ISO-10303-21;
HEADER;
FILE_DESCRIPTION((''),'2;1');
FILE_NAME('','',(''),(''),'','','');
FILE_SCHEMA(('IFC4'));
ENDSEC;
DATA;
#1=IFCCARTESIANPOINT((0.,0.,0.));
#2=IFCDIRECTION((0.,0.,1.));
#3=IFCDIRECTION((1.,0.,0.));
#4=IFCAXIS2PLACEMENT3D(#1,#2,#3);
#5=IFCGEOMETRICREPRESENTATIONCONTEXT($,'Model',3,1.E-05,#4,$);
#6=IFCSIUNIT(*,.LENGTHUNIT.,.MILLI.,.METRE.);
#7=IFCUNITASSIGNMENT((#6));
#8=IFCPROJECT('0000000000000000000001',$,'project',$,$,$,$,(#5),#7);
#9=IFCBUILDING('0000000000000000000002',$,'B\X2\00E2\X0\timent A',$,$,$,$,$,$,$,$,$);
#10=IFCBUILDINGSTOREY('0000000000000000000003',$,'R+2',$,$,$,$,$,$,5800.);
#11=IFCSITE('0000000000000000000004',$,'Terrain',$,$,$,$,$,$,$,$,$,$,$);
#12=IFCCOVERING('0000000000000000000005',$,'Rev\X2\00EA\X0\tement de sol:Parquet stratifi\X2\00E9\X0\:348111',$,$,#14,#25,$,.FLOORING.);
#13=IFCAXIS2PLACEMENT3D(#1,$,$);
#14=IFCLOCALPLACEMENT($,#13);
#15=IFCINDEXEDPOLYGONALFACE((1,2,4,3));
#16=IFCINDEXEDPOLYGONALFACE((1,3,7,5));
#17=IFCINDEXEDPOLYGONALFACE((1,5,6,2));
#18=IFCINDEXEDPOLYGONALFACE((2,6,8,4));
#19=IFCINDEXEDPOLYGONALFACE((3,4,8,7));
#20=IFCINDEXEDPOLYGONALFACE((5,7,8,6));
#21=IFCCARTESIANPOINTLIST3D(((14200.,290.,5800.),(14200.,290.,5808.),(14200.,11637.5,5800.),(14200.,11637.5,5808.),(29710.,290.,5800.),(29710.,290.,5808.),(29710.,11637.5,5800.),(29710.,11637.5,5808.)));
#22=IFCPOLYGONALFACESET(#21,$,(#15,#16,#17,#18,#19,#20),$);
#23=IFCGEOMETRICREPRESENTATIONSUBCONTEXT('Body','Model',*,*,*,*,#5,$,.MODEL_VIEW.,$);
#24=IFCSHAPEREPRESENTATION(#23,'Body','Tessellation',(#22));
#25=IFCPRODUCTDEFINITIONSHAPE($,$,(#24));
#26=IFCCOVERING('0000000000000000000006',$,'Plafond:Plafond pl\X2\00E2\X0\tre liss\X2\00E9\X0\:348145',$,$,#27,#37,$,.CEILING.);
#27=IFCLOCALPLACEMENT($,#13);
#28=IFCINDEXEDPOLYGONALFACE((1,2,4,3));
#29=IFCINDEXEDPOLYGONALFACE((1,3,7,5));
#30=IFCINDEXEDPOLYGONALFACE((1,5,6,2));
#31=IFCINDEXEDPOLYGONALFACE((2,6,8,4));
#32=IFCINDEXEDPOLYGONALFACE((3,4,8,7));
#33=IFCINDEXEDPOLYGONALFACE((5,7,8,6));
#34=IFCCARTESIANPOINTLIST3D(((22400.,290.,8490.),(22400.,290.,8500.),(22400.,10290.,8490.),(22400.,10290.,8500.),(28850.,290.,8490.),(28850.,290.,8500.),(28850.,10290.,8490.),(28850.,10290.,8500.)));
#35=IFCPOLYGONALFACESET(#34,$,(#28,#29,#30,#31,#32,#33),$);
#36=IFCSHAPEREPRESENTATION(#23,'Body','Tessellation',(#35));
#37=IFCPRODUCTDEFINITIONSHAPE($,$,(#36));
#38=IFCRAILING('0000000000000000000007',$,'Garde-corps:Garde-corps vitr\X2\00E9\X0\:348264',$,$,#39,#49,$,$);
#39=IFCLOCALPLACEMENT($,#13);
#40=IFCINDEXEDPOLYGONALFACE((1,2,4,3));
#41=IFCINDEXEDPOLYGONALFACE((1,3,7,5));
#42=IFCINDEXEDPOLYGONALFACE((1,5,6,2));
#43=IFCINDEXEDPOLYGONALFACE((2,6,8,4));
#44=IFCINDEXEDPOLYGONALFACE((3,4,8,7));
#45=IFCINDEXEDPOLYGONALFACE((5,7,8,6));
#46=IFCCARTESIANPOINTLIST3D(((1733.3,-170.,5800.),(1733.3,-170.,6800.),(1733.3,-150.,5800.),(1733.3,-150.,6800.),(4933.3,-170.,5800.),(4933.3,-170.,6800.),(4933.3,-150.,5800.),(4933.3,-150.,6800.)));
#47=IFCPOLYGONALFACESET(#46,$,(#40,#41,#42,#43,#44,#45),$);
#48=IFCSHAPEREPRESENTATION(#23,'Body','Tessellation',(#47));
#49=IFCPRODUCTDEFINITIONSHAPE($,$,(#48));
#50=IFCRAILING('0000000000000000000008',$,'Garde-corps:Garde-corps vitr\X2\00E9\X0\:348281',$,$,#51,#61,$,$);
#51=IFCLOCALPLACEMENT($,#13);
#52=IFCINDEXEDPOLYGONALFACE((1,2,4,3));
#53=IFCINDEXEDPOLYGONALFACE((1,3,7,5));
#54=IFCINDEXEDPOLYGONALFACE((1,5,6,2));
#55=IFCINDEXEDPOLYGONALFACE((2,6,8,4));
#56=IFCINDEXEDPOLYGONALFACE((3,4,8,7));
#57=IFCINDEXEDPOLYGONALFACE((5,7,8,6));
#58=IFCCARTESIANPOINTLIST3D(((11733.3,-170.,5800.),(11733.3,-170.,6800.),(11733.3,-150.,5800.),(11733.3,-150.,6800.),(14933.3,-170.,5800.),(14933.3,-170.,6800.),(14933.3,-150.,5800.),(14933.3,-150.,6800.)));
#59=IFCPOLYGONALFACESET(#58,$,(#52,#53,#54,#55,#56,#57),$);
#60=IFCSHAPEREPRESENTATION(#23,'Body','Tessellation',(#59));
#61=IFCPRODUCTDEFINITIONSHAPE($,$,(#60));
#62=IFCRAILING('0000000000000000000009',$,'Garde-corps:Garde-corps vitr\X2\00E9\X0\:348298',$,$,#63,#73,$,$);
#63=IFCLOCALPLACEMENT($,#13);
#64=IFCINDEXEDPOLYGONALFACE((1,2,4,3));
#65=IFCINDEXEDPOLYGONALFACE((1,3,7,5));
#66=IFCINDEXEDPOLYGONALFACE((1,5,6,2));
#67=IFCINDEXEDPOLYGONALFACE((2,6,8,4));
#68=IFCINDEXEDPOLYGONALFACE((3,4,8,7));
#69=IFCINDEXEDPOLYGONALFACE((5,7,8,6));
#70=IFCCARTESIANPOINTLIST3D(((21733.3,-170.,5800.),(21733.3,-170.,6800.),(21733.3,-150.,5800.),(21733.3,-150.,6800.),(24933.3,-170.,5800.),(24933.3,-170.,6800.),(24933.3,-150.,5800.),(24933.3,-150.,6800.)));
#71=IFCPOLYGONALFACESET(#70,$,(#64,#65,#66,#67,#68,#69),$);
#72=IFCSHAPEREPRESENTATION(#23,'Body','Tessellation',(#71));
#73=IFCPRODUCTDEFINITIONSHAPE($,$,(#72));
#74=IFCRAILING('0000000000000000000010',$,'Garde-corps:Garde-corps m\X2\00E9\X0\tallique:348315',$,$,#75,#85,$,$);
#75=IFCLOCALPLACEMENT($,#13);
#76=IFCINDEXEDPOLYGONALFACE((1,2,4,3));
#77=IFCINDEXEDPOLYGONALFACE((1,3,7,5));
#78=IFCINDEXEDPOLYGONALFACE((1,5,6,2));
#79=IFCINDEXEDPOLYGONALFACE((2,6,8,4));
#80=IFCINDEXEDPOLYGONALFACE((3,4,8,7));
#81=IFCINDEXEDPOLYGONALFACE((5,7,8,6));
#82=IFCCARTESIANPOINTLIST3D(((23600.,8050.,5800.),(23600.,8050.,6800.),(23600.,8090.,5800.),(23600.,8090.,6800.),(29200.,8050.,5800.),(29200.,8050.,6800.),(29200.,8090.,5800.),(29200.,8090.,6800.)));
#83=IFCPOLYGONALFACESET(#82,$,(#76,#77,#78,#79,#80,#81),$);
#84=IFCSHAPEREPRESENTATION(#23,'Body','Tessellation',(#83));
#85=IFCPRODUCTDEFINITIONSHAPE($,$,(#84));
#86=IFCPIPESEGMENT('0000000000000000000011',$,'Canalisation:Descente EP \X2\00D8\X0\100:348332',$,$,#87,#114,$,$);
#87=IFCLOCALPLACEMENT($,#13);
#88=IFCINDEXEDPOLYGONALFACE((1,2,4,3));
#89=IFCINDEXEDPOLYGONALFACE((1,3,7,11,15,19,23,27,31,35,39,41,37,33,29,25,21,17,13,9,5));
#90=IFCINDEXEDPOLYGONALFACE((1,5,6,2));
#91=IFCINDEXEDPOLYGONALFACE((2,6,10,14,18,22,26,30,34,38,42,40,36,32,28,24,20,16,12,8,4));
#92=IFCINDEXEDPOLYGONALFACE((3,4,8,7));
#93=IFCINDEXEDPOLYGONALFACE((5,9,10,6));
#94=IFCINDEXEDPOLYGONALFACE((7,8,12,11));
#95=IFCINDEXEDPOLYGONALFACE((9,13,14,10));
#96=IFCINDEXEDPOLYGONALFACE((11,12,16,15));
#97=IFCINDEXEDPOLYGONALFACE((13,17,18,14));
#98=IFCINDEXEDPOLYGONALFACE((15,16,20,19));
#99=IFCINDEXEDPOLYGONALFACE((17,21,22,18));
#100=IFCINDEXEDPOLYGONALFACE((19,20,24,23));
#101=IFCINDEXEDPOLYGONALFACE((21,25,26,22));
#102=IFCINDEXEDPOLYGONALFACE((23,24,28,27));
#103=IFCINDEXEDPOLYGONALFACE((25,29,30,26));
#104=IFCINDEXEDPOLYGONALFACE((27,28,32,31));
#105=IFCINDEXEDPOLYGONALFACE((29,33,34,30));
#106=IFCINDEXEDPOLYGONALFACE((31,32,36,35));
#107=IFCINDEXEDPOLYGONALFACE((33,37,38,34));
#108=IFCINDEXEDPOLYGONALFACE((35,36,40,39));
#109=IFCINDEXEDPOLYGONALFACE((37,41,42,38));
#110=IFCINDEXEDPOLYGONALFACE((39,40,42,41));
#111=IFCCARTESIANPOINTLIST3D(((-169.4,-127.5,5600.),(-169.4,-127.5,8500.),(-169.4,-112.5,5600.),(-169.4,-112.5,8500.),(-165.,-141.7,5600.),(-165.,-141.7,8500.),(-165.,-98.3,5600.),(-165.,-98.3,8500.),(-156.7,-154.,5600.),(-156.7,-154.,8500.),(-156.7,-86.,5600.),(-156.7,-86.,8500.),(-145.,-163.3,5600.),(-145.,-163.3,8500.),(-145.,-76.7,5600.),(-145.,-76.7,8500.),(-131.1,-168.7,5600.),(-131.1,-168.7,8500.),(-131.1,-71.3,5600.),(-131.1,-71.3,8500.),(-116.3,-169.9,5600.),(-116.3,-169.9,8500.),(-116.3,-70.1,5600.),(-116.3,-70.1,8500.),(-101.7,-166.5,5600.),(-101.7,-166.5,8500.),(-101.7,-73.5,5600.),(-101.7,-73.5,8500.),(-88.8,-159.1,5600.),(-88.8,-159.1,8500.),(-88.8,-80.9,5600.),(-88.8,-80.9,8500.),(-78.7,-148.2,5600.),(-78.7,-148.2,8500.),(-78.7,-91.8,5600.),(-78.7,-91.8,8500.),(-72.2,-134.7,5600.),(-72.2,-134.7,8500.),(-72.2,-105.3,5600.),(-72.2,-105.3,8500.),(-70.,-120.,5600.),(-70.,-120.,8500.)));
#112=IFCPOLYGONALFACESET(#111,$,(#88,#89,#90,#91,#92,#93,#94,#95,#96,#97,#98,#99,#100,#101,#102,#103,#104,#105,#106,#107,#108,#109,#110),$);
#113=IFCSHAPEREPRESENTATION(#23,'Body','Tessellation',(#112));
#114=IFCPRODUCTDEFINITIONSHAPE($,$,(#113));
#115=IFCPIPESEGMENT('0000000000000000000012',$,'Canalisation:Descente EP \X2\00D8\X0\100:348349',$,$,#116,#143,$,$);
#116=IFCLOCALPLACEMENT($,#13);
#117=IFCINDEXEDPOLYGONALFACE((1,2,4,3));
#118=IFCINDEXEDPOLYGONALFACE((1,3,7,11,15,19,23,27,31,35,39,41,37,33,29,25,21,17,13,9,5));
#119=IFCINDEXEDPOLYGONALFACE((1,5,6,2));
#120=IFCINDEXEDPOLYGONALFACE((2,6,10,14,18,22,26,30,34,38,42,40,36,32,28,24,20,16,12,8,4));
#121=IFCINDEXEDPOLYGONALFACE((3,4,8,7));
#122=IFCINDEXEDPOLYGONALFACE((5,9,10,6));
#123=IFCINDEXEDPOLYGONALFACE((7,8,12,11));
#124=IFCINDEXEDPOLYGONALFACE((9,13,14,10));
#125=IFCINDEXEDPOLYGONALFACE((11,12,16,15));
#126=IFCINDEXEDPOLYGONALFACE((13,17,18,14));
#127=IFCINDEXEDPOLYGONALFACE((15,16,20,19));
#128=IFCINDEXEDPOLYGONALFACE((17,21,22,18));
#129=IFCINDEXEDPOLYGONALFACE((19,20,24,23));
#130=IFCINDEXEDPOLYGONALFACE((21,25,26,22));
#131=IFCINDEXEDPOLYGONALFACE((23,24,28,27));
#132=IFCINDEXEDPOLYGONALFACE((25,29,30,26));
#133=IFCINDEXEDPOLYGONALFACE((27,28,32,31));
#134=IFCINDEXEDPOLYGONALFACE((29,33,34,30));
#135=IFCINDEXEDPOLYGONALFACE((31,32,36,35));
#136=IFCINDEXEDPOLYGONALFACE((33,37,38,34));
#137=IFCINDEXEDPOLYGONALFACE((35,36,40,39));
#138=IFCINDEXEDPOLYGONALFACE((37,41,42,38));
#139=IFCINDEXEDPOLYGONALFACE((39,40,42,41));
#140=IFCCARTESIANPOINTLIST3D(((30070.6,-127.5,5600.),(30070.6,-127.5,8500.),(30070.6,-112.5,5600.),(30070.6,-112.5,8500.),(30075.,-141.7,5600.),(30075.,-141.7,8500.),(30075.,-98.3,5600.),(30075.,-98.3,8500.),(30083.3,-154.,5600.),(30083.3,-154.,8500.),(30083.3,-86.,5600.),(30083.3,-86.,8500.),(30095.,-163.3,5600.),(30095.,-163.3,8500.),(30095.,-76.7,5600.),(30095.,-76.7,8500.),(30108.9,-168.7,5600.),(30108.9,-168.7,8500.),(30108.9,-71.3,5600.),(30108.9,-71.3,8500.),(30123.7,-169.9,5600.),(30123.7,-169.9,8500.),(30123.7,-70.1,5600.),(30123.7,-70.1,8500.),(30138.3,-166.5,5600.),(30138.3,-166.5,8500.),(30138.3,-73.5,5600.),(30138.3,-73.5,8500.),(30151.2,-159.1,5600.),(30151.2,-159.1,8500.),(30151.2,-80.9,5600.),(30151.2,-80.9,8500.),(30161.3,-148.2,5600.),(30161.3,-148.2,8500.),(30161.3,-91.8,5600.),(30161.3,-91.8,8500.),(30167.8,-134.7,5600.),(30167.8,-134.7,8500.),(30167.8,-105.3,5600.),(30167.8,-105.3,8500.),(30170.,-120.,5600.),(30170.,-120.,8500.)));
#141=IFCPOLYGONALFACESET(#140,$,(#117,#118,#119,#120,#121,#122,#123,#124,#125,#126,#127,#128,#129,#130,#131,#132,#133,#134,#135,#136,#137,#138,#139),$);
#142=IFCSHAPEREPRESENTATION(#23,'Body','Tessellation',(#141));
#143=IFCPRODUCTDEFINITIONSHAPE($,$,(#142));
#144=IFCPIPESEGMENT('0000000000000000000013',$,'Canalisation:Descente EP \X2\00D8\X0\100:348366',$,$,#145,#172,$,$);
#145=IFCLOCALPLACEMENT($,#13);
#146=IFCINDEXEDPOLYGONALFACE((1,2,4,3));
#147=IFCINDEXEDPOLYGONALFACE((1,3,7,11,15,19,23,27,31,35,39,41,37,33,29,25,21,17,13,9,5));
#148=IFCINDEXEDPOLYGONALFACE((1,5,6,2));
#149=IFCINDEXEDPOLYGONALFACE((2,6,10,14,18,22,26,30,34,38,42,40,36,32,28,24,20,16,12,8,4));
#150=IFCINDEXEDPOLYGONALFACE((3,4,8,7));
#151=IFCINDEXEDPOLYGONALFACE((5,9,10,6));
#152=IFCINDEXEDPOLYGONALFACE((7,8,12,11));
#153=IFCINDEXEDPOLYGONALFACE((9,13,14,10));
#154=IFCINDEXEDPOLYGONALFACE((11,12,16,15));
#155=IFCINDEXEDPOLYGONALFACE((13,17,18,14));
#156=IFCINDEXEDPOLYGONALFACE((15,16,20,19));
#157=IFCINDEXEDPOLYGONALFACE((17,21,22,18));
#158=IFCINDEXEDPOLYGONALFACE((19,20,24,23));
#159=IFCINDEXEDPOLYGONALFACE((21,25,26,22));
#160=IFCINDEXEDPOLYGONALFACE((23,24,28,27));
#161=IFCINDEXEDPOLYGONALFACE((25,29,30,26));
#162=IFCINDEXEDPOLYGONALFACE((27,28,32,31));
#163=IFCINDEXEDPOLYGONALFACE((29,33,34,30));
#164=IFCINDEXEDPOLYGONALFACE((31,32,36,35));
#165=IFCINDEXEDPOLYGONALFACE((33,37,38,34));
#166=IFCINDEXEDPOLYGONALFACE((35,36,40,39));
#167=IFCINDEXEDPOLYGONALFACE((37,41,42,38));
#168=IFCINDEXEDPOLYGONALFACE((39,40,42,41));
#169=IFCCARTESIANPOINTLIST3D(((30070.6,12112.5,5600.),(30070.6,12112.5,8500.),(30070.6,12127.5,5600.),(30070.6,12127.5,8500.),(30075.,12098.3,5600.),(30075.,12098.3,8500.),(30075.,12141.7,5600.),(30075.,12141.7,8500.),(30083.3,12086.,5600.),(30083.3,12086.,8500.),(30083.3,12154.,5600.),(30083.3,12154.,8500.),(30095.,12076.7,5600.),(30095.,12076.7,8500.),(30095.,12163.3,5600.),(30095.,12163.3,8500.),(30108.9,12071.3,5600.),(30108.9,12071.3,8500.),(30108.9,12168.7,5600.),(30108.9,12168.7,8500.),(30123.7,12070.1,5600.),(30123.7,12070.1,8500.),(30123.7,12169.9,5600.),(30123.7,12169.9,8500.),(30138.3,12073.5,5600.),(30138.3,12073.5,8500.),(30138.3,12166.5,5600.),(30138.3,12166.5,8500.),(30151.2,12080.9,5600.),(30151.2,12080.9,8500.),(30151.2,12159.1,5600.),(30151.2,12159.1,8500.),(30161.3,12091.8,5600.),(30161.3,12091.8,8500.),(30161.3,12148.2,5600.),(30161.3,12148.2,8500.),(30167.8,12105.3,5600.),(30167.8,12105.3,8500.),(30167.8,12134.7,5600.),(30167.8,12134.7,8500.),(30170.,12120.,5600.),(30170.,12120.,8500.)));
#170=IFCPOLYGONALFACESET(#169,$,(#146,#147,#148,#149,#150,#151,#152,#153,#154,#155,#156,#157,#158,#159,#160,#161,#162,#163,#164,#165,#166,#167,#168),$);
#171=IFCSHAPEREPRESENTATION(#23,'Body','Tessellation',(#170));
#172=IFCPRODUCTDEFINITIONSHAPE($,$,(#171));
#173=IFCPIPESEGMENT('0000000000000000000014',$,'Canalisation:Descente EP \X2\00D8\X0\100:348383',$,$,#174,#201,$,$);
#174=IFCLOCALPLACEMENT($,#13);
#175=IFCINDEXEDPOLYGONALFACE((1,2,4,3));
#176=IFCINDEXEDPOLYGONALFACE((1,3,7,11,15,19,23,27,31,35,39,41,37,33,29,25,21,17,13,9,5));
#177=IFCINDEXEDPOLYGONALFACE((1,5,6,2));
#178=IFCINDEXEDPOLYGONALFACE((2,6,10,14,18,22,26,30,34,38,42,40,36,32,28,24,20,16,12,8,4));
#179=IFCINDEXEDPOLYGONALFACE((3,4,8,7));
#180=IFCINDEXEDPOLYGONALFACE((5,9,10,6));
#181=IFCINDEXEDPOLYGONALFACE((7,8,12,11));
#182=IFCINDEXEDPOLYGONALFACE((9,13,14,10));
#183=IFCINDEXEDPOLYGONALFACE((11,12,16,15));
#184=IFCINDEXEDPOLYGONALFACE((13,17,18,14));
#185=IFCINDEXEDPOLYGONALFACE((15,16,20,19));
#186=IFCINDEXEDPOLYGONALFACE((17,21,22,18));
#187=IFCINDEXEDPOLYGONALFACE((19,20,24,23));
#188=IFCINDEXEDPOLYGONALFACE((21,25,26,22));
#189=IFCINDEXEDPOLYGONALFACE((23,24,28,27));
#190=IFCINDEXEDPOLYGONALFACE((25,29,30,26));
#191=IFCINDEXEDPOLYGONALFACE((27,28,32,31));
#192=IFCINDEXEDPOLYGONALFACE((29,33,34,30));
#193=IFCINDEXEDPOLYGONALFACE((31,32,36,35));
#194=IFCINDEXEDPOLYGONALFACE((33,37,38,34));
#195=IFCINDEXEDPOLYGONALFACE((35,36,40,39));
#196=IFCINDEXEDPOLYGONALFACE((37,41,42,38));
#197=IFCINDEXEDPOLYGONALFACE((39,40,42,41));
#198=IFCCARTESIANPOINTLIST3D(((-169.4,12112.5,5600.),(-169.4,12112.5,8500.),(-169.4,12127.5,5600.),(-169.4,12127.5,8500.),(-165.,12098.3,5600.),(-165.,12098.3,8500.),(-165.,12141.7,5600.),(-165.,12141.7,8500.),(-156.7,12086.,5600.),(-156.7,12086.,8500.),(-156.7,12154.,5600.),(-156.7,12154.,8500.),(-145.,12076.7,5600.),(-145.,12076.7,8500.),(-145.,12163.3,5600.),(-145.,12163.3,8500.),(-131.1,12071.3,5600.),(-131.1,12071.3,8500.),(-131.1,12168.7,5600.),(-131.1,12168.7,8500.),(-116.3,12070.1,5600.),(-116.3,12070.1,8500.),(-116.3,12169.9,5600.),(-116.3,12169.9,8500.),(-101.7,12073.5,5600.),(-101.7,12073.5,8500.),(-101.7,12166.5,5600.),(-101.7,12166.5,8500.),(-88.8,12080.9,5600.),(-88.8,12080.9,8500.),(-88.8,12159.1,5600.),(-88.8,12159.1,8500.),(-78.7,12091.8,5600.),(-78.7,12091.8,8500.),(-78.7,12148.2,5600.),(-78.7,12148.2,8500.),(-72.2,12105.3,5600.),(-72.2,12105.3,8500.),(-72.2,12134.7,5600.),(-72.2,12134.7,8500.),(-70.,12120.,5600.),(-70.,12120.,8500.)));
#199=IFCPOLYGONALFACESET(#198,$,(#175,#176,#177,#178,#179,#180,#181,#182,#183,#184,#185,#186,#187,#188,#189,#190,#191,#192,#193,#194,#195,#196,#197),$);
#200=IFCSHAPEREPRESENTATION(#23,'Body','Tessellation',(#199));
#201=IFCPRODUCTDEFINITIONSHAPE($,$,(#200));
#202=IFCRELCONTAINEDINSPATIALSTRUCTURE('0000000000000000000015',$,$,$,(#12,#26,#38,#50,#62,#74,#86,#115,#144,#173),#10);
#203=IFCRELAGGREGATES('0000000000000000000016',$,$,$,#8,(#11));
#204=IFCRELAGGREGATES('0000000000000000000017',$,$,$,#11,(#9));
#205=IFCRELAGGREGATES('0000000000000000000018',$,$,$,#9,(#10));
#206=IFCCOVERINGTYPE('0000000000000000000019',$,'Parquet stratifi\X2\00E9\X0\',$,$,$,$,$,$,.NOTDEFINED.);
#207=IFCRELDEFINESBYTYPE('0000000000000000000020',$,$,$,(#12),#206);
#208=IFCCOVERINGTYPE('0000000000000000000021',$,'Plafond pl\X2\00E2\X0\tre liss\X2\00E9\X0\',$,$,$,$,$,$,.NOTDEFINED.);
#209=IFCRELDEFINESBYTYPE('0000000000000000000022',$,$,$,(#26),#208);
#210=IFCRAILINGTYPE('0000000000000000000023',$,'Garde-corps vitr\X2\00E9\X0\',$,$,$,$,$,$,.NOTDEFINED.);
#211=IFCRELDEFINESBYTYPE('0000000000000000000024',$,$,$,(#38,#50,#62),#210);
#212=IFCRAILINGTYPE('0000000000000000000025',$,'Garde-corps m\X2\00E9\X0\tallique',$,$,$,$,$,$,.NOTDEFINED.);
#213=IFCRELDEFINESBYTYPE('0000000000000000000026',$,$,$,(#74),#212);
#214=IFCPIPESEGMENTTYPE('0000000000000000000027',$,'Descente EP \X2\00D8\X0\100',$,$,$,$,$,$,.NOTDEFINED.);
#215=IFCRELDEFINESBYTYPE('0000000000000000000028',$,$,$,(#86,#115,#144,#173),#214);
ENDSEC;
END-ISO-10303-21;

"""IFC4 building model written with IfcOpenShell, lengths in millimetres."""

from ifc_helpers import new_model, si_unit, frame, frame_2d, origin_with_axes, origin_2d, place, context, subcontext, project, spatial, rectangle, circle, extrude, type_object, element, save


model = new_model("IFC4")

# Units and contexts
model_context = context("Model", 3, precision=1e-05, world=origin_with_axes())
body_context = subcontext(model_context, "Body", "Model", "MODEL_VIEW")
ifc_project = project(units=[si_unit("LENGTHUNIT", "METRE", prefix="MILLI")], contexts=[model_context])

# Site, building, storey
site = spatial("IfcSite", under=ifc_project, Name="Terrain")
building = spatial("IfcBuilding", under=site, Name="Bâtiment A")
storey = spatial("IfcBuildingStorey", under=building, Name="R+2", Elevation=5800.0)

# Coverings
covering_type_1 = type_object("IfcCoveringType", Name="Parquet stratifié", PredefinedType="NOTDEFINED")
covering_1_placement = place(None, origin_with_axes())
element("IfcCovering", 1, at=covering_1_placement, inside=storey, type_object=covering_type_1, Name="Revêtement de sol:Parquet stratifié:348111", PredefinedType="FLOORING", context=body_context, shape_type="SweptSolid", body=[
    extrude(rectangle(XDim=15510.0, YDim=11347.5, at=frame_2d((21955.0, 5963.8))), frame((0.0, 0.0, 5800.0), z_axis=(0.0, 0.0, 1.0), x_axis=(1.0, 0.0, 0.0)), (0.0, 0.0, 1.0), 8.0),
])
covering_type_2 = type_object("IfcCoveringType", Name="Plafond plâtre lissé", PredefinedType="NOTDEFINED")
covering_2_placement = place(None, origin_with_axes())
element("IfcCovering", 2, at=covering_2_placement, inside=storey, type_object=covering_type_2, Name="Plafond:Plafond plâtre lissé:348145", PredefinedType="CEILING", context=body_context, shape_type="SweptSolid", body=[
    extrude(rectangle(XDim=6450.0, YDim=10000.0, at=frame_2d((25625.0, 5290.0))), frame((0.0, 0.0, 8490.0), z_axis=(0.0, 0.0, 1.0), x_axis=(1.0, 0.0, 0.0)), (0.0, 0.0, 1.0), 10.0),
])

# Railings
railing_type_1 = type_object("IfcRailingType", Name="Garde-corps vitré", PredefinedType="NOTDEFINED")
railing_1_placement = place(None, origin_with_axes())
element("IfcRailing", 3, at=railing_1_placement, inside=storey, type_object=railing_type_1, Name="Garde-corps:Garde-corps vitré:348264", context=body_context, shape_type="SweptSolid", body=[
    extrude(rectangle(XDim=3200.0, YDim=20.0, at=frame_2d((3333.3, -160.0))), frame((0.0, 0.0, 5800.0), z_axis=(0.0, 0.0, 1.0), x_axis=(1.0, 0.0, 0.0)), (0.0, 0.0, 1.0), 1000.0),
])
railing_2_placement = place(None, origin_with_axes())
element("IfcRailing", 4, at=railing_2_placement, inside=storey, type_object=railing_type_1, Name="Garde-corps:Garde-corps vitré:348281", context=body_context, shape_type="SweptSolid", body=[
    extrude(rectangle(XDim=3200.0, YDim=20.0, at=frame_2d((13333.3, -160.0))), frame((0.0, 0.0, 5800.0), z_axis=(0.0, 0.0, 1.0), x_axis=(1.0, 0.0, 0.0)), (0.0, 0.0, 1.0), 1000.0),
])
railing_3_placement = place(None, origin_with_axes())
element("IfcRailing", 5, at=railing_3_placement, inside=storey, type_object=railing_type_1, Name="Garde-corps:Garde-corps vitré:348298", context=body_context, shape_type="SweptSolid", body=[
    extrude(rectangle(XDim=3200.0, YDim=20.0, at=frame_2d((23333.3, -160.0))), frame((0.0, 0.0, 5800.0), z_axis=(0.0, 0.0, 1.0), x_axis=(1.0, 0.0, 0.0)), (0.0, 0.0, 1.0), 1000.0),
])
railing_type_2 = type_object("IfcRailingType", Name="Garde-corps métallique", PredefinedType="NOTDEFINED")
railing_4_placement = place(None, origin_with_axes())
element("IfcRailing", 6, at=railing_4_placement, inside=storey, type_object=railing_type_2, Name="Garde-corps:Garde-corps métallique:348315", context=body_context, shape_type="SweptSolid", body=[
    extrude(rectangle(XDim=5600.0, YDim=40.0, at=frame_2d((26400.0, 8070.0))), frame((0.0, 0.0, 5800.0), z_axis=(0.0, 0.0, 1.0), x_axis=(1.0, 0.0, 0.0)), (0.0, 0.0, 1.0), 1000.0),
])

# Pipe segments
pipe_segment_type = type_object("IfcPipeSegmentType", Name="Descente EP Ø100", PredefinedType="NOTDEFINED")
pipe_segment_1_placement = place(None, origin_with_axes())
element("IfcPipeSegment", 7, at=pipe_segment_1_placement, inside=storey, type_object=pipe_segment_type, Name="Canalisation:Descente EP Ø100:348332", context=body_context, shape_type="SweptSolid", body=[
    extrude(circle(Radius=50.0, at=origin_2d()), frame((-120.0, -120.0, 5600.0), z_axis=(0.0, 0.0, 1.0), x_axis=(1.0, 0.0, 0.0)), (0.0, 0.0, 1.0), 2900.0),
])
pipe_segment_2_placement = place(None, origin_with_axes())
element("IfcPipeSegment", 8, at=pipe_segment_2_placement, inside=storey, type_object=pipe_segment_type, Name="Canalisation:Descente EP Ø100:348349", context=body_context, shape_type="SweptSolid", body=[
    extrude(circle(Radius=50.0, at=origin_2d()), frame((30120.0, -120.0, 5600.0), z_axis=(0.0, 0.0, 1.0), x_axis=(1.0, 0.0, 0.0)), (0.0, 0.0, 1.0), 2900.0),
])
pipe_segment_3_placement = place(None, origin_with_axes())
element("IfcPipeSegment", 9, at=pipe_segment_3_placement, inside=storey, type_object=pipe_segment_type, Name="Canalisation:Descente EP Ø100:348366", context=body_context, shape_type="SweptSolid", body=[
    extrude(circle(Radius=50.0, at=origin_2d()), frame((30120.0, 12120.0, 5600.0), z_axis=(0.0, 0.0, 1.0), x_axis=(1.0, 0.0, 0.0)), (0.0, 0.0, 1.0), 2900.0),
])
pipe_segment_4_placement = place(None, origin_with_axes())
element("IfcPipeSegment", 10, at=pipe_segment_4_placement, inside=storey, type_object=pipe_segment_type, Name="Canalisation:Descente EP Ø100:348383", context=body_context, shape_type="SweptSolid", body=[
    extrude(circle(Radius=50.0, at=origin_2d()), frame((-120.0, 12120.0, 5600.0), z_axis=(0.0, 0.0, 1.0), x_axis=(1.0, 0.0, 0.0)), (0.0, 0.0, 1.0), 2900.0),
])

save(model, "model.ifc")
